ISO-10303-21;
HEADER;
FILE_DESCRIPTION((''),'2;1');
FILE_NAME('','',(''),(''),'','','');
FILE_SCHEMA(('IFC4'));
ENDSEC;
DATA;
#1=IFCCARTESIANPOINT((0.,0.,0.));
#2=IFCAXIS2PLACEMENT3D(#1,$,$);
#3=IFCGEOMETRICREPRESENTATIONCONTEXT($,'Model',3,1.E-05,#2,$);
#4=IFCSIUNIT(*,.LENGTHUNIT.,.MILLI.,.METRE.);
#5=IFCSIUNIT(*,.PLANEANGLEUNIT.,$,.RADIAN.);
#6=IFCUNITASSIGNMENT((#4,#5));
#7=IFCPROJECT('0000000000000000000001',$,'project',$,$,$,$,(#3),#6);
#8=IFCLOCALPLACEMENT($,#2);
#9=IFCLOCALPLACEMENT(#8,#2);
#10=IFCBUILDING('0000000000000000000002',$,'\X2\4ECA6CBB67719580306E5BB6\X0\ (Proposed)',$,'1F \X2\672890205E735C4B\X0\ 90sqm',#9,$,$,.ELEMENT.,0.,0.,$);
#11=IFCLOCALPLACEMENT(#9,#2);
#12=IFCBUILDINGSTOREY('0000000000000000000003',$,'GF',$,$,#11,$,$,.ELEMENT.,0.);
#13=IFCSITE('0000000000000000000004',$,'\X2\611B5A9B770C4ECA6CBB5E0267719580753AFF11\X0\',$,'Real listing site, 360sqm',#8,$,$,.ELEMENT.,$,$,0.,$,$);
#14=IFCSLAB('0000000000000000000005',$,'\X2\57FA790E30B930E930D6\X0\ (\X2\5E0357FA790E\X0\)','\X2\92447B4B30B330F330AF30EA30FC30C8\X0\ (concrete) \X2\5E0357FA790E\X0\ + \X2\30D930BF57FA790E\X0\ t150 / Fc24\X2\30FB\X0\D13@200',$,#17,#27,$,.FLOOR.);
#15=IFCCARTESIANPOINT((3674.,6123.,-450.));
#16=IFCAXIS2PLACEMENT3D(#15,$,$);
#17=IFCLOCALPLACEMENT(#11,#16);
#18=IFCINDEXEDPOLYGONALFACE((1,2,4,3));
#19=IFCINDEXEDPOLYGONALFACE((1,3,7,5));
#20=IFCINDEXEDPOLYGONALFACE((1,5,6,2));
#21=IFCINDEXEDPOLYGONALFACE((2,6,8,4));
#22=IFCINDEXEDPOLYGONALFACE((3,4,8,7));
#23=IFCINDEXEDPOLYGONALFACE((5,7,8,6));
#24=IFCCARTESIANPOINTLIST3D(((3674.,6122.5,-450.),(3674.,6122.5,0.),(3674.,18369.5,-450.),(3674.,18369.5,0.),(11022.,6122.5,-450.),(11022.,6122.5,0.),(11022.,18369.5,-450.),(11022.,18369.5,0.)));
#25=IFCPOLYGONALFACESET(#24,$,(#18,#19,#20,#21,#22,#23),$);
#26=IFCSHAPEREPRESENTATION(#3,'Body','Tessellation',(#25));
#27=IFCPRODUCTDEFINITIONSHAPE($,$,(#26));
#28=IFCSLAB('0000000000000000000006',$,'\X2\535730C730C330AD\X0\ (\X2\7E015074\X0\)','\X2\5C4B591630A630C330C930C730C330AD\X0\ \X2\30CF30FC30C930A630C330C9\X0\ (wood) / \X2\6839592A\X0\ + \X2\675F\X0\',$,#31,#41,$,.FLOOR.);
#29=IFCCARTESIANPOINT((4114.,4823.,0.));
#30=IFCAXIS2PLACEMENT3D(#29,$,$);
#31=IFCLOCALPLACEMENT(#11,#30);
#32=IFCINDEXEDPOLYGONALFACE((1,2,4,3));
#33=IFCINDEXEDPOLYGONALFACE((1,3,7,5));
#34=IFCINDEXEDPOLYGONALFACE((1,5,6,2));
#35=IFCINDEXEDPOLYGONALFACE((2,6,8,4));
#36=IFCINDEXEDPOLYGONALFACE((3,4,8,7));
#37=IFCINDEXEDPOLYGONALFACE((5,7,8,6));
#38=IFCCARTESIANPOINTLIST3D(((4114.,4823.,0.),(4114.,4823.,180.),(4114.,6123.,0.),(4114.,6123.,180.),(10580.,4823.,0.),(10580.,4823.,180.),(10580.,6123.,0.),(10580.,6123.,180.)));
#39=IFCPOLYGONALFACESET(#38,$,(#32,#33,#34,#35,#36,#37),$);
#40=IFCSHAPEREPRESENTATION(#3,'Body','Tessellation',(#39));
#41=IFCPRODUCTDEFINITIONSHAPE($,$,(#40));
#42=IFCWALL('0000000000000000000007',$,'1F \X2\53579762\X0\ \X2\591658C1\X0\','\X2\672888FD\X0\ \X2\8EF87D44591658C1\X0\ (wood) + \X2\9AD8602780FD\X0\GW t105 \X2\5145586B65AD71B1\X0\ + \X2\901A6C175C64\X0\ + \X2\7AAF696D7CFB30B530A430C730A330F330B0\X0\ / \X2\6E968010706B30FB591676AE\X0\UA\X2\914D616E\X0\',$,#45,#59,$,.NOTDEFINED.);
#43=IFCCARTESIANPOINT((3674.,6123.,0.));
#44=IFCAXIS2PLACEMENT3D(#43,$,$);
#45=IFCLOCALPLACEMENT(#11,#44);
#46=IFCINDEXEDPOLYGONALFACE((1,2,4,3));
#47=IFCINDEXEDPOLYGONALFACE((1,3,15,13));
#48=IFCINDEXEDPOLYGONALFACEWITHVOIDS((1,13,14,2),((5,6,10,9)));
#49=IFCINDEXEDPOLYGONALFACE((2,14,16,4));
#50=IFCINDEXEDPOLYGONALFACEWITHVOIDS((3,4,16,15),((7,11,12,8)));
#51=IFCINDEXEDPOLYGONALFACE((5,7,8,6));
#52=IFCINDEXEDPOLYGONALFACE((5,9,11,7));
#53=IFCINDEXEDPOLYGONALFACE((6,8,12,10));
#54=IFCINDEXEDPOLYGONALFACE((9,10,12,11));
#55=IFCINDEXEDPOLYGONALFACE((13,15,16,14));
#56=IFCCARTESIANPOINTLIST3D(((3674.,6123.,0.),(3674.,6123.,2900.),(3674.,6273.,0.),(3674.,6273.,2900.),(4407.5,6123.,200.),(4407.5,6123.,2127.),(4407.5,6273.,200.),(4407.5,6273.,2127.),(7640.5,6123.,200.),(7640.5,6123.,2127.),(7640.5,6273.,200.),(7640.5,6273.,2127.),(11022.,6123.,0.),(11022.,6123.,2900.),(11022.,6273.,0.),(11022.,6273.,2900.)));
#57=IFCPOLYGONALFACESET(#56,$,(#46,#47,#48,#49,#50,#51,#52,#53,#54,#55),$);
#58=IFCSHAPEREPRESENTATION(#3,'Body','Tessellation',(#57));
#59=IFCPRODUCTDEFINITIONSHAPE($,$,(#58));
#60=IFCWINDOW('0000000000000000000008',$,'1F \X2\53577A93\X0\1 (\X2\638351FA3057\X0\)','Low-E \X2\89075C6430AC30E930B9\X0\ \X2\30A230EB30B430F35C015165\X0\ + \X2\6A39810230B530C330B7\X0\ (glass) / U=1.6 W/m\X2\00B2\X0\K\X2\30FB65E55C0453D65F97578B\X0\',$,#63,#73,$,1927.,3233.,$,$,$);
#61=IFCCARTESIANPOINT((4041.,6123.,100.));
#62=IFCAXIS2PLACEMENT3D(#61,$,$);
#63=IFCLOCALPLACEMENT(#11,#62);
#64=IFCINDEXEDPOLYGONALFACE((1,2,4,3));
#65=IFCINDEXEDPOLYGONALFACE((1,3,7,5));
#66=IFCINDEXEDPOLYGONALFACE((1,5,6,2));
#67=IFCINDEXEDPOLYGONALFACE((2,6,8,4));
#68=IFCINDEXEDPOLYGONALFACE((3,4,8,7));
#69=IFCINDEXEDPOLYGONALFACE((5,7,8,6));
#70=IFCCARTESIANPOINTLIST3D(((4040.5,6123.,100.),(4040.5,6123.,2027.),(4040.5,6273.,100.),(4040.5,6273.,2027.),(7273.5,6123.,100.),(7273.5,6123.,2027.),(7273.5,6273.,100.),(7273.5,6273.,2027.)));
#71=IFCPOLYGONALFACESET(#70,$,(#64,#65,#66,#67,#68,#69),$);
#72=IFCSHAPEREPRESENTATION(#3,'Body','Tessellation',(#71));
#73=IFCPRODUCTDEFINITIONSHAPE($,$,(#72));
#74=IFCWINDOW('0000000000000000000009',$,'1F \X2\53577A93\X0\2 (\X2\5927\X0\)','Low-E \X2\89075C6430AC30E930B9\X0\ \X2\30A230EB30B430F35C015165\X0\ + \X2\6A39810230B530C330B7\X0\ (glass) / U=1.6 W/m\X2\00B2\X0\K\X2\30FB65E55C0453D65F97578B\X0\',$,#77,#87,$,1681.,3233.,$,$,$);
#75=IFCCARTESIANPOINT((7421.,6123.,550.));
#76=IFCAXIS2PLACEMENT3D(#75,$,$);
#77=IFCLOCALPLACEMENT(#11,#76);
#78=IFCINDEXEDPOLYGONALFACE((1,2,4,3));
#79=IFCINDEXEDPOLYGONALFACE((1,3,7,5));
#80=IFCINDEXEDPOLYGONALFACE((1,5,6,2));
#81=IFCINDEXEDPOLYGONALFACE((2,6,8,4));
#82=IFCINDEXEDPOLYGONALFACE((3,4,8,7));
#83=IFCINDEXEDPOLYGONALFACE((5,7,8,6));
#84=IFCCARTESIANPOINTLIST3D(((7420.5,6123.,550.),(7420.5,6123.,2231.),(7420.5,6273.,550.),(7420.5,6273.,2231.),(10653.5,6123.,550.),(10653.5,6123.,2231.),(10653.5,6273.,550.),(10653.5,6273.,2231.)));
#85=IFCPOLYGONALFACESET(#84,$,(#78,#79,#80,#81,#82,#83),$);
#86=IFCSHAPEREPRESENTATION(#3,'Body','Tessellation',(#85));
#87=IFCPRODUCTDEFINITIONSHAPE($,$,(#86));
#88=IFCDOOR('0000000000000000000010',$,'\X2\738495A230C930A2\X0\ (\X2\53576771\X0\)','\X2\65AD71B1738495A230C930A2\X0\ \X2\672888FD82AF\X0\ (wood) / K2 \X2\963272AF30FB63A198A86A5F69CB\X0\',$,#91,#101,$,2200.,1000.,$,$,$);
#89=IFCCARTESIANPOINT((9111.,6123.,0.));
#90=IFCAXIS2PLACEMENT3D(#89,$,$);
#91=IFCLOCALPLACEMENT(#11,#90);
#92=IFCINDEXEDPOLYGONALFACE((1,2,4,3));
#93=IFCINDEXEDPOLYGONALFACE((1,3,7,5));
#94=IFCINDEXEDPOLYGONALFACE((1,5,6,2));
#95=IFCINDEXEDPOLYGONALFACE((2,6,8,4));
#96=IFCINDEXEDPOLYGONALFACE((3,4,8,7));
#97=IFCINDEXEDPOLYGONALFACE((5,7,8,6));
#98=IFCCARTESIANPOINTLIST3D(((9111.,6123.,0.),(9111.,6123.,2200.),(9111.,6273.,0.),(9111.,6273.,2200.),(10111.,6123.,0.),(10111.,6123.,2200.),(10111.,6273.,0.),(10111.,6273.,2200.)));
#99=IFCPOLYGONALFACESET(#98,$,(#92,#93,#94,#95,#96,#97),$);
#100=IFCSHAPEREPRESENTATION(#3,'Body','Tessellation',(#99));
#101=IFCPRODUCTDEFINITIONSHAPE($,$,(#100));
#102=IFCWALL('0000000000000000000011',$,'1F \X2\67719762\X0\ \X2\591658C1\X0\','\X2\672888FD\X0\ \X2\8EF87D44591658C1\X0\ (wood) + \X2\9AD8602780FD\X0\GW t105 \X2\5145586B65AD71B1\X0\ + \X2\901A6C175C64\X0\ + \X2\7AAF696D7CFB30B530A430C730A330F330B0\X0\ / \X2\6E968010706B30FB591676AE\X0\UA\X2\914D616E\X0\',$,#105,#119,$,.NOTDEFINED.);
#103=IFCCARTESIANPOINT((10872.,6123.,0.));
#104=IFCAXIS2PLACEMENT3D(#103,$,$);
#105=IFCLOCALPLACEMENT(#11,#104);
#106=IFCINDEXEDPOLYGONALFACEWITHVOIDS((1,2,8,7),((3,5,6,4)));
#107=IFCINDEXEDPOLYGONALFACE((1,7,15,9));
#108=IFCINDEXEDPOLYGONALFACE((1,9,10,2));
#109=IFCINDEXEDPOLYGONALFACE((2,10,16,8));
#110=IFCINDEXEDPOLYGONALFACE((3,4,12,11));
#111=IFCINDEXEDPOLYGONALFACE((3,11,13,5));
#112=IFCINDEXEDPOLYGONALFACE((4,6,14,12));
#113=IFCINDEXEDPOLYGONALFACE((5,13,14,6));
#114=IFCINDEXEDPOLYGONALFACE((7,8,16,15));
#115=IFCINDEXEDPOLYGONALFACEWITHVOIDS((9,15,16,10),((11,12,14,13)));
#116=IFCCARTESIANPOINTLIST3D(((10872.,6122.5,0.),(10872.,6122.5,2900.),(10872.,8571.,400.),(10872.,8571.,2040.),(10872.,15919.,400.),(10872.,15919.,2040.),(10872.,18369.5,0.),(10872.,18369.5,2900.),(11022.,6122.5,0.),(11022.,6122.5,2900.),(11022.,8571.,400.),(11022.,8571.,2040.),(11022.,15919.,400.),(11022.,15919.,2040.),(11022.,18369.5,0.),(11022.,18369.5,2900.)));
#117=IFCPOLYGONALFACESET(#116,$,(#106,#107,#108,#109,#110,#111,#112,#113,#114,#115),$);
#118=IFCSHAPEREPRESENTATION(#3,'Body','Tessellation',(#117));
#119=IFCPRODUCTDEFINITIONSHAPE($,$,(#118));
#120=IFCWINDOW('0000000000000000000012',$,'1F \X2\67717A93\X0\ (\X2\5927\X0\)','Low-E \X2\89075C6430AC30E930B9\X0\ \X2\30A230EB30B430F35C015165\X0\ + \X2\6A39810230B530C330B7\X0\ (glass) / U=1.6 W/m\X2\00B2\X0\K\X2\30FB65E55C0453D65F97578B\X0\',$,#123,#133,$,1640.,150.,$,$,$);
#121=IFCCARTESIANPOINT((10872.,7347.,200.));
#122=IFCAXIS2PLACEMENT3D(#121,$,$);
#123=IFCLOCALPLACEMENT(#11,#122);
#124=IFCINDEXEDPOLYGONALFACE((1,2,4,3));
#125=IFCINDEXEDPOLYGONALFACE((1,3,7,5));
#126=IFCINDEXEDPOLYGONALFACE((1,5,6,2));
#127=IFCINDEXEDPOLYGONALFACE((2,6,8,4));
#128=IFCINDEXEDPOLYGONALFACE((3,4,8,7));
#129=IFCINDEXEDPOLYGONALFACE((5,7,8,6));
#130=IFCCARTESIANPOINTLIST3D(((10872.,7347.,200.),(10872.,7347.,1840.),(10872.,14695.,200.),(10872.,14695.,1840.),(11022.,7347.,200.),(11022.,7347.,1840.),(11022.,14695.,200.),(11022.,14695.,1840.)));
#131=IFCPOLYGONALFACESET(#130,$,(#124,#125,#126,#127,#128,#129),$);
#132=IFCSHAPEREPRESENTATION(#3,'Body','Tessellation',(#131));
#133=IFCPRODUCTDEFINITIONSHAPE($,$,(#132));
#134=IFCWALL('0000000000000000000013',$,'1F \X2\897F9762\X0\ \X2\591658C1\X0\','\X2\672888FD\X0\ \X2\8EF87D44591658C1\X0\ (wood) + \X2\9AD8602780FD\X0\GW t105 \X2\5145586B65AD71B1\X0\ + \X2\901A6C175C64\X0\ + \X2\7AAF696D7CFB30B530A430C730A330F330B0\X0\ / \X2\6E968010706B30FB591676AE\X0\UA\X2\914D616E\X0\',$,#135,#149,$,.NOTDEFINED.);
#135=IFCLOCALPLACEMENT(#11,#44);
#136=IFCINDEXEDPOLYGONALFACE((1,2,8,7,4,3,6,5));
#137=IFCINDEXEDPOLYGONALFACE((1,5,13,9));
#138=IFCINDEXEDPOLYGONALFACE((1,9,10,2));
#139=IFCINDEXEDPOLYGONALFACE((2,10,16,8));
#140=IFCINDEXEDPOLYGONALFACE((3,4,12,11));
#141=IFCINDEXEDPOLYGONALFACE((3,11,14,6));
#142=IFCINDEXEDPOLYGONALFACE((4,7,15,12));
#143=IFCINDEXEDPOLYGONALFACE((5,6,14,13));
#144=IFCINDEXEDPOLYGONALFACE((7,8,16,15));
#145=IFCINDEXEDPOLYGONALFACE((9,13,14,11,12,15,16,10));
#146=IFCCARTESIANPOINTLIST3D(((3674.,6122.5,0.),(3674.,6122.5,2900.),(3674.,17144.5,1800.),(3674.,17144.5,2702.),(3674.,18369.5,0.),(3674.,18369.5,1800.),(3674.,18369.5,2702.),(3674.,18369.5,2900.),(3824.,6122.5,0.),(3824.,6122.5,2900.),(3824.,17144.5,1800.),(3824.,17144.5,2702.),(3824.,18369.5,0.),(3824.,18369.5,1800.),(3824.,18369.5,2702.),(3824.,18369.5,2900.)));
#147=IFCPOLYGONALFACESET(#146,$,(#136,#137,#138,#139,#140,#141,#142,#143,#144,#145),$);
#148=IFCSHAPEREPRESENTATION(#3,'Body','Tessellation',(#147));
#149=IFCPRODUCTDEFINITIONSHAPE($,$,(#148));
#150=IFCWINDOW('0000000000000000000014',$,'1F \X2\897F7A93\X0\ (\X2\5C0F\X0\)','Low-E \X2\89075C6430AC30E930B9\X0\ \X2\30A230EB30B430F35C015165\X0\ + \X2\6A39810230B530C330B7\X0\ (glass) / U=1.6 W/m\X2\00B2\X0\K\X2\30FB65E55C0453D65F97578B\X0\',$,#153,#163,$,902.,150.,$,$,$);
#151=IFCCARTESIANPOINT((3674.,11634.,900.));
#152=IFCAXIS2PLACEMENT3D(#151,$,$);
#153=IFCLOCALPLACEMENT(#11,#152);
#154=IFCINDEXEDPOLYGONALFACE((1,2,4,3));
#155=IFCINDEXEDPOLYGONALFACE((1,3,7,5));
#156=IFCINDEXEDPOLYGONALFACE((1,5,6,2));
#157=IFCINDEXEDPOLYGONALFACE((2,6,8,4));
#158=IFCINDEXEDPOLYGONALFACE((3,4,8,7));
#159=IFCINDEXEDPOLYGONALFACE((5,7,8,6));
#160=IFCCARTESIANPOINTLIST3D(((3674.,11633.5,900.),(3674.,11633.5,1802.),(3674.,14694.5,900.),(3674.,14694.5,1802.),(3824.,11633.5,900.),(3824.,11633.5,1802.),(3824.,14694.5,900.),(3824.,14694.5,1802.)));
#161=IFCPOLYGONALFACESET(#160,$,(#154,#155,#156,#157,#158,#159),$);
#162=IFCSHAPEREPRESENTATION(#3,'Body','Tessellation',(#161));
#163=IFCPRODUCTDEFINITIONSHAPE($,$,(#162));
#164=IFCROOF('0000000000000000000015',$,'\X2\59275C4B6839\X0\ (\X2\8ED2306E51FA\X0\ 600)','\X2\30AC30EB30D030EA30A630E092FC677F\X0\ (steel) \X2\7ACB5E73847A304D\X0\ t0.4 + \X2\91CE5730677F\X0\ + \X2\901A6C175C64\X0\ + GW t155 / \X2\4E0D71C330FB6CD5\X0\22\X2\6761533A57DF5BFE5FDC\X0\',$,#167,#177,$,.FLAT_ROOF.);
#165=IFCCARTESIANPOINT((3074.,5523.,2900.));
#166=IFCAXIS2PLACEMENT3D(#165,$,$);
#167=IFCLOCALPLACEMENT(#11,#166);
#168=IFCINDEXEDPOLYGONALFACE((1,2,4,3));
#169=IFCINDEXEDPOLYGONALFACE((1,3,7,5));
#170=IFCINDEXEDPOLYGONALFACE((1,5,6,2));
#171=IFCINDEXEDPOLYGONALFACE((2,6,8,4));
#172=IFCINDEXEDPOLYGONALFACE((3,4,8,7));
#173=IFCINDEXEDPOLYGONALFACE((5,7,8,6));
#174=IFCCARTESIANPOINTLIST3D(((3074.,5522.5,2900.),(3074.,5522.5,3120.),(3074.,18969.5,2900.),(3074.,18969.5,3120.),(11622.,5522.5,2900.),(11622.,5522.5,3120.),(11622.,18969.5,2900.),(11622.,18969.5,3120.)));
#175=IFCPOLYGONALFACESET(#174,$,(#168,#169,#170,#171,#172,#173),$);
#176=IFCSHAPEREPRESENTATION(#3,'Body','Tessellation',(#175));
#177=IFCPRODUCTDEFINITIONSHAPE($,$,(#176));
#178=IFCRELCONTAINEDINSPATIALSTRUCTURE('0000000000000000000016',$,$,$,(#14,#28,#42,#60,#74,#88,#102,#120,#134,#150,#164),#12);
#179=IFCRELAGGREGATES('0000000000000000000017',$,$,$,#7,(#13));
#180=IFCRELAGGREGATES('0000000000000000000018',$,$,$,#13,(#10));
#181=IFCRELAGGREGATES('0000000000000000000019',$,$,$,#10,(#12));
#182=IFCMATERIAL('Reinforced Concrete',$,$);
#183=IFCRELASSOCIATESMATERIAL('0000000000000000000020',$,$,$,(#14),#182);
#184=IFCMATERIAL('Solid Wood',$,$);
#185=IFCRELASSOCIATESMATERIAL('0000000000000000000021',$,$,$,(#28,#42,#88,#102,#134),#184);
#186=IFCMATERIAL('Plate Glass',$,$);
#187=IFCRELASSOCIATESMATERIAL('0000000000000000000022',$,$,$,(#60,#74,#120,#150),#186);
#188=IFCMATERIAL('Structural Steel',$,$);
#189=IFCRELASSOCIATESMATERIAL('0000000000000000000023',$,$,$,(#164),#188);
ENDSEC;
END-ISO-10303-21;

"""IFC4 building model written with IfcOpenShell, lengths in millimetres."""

from ifc_helpers import new_model, si_unit, frame, frame_2d, origin, place, context, project, spatial, rectangle, extrude, material, element, fill, save


model = new_model("IFC4")

# Units and contexts
model_context = context("Model", 3, precision=1e-05, world=origin())
ifc_project = project(units=[si_unit("LENGTHUNIT", "METRE", prefix="MILLI"), si_unit("PLANEANGLEUNIT", "RADIAN")], contexts=[model_context])

# Site, building, storey
site_placement = place(None, origin())
site = spatial("IfcSite", under=ifc_project, at=site_placement, Name="愛媛県今治市東門町１", ObjectType="Real listing site, 360sqm", CompositionType="ELEMENT", RefElevation=0.0)
building_placement = place(site_placement, origin())
building = spatial("IfcBuilding", under=site, at=building_placement, Name="今治東門の家 (Proposed)", ObjectType="1F 木造平屋 90sqm", CompositionType="ELEMENT", ElevationOfRefHeight=0.0, ElevationOfTerrain=0.0)
storey_placement = place(building_placement, origin())
storey = spatial("IfcBuildingStorey", under=building, at=storey_placement, Name="GF", CompositionType="ELEMENT", Elevation=0.0)

# Slabs
ifc_material_1 = material(Name="Reinforced Concrete")
slab_1_placement = place(storey_placement, frame((3674.0, 6123.0, -450.0)))
element("IfcSlab", 1, at=slab_1_placement, inside=storey, material=ifc_material_1, Name="基礎スラブ (布基礎)", Description="鉄筋コンクリート (concrete) 布基礎 + ベタ基礎 t150 / Fc24・D13@200", PredefinedType="FLOOR", context=model_context, shape_type="SweptSolid", body=[
    extrude(rectangle(XDim=7348.0, YDim=12247.0, at=frame_2d((3674.0, 6123.0))), frame((3674.0, 6123.0, -450.0)), (0.0, 0.0, 1.0), 450.0),
])
ifc_material_2 = material(Name="Solid Wood")
slab_2_placement = place(storey_placement, frame((4114.0, 4823.0, 0.0)))
element("IfcSlab", 2, at=slab_2_placement, inside=storey, material=ifc_material_2, Name="南デッキ (縁側)", Description="屋外ウッドデッキ ハードウッド (wood) / 根太 + 束", PredefinedType="FLOOR", context=model_context, shape_type="SweptSolid", body=[
    extrude(rectangle(XDim=6466.0, YDim=1300.0, at=frame_2d((3233.0, 650.0))), frame((4114.0, 4823.0, 0.0)), (0.0, 0.0, 1.0), 180.0),
])

# Wall, openings, windows, door
wall_1_placement = place(storey_placement, frame((3674.0, 6123.0, 0.0)))
wall_1 = element("IfcWall", 3, at=wall_1_placement, inside=storey, material=ifc_material_2, Name="1F 南面 外壁", Description="木製 軸組外壁 (wood) + 高性能GW t105 充填断熱 + 通気層 + 窯業系サイディング / 準耐火・外皮UA配慮", PredefinedType="NOTDEFINED", context=model_context, shape_type="SweptSolid", body=[
    extrude(rectangle(XDim=7348.0, YDim=150.0, at=frame_2d((3674.0, 75.0))), frame((3674.0, 6123.0, 0.0)), (0.0, 0.0, 1.0), 2900.0),
])
opening_1_placement = place(storey_placement, frame((4041.0, 6123.0, 100.0)))
opening_1 = element("IfcOpeningElement", 4, at=opening_1_placement, cuts=wall_1, PredefinedType="NOTDEFINED", context=model_context, shape_type="SweptSolid", body=[
    extrude(rectangle(XDim=3233.0, YDim=150.0, at=frame_2d((1616.0, 75.0))), frame((4041.0, 6123.0, 100.0)), (0.0, 0.0, 1.0), 1927.0),
])
opening_2_placement = place(storey_placement, frame((7421.0, 6123.0, 550.0)))
opening_2 = element("IfcOpeningElement", 5, at=opening_2_placement, cuts=wall_1, PredefinedType="NOTDEFINED", context=model_context, shape_type="SweptSolid", body=[
    extrude(rectangle(XDim=3233.0, YDim=150.0, at=frame_2d((1616.0, 75.0))), frame((7421.0, 6123.0, 550.0)), (0.0, 0.0, 1.0), 1681.0),
])
opening_3_placement = place(storey_placement, frame((9111.0, 6123.0, 0.0)))
opening_3 = element("IfcOpeningElement", 6, at=opening_3_placement, cuts=wall_1, PredefinedType="NOTDEFINED", context=model_context, shape_type="SweptSolid", body=[
    extrude(rectangle(XDim=1000.0, YDim=150.0, at=frame_2d((500.0, 75.0))), frame((9111.0, 6123.0, 0.0)), (0.0, 0.0, 1.0), 2200.0),
])
ifc_material_3 = material(Name="Plate Glass")
window_1_placement = place(storey_placement, frame((4041.0, 6123.0, 100.0)))
window_1 = element("IfcWindow", 7, at=window_1_placement, inside=storey, material=ifc_material_3, Name="1F 南窓1 (掃出し)", Description="Low-E 複層ガラス アルゴン封入 + 樹脂サッシ (glass) / U=1.6 W/m²K・日射取得型", OverallHeight=1927.0, OverallWidth=3233.0, context=model_context, shape_type="SweptSolid", body=[
    extrude(rectangle(XDim=3233.0, YDim=150.0, at=frame_2d((1616.0, 75.0))), frame((4041.0, 6123.0, 100.0)), (0.0, 0.0, 1.0), 1927.0),
])
fill(opening_1, window_1)
window_2_placement = place(storey_placement, frame((7421.0, 6123.0, 550.0)))
window_2 = element("IfcWindow", 8, at=window_2_placement, inside=storey, material=ifc_material_3, Name="1F 南窓2 (大)", Description="Low-E 複層ガラス アルゴン封入 + 樹脂サッシ (glass) / U=1.6 W/m²K・日射取得型", OverallHeight=1681.0, OverallWidth=3233.0, context=model_context, shape_type="SweptSolid", body=[
    extrude(rectangle(XDim=3233.0, YDim=150.0, at=frame_2d((1616.0, 75.0))), frame((7421.0, 6123.0, 550.0)), (0.0, 0.0, 1.0), 1681.0),
])
fill(opening_2, window_2)
door_placement = place(storey_placement, frame((9111.0, 6123.0, 0.0)))
door = element("IfcDoor", 9, at=door_placement, inside=storey, material=ifc_material_2, Name="玄関ドア (南東)", Description="断熱玄関ドア 木製芯 (wood) / K2 防犯・採風機構", OverallHeight=2200.0, OverallWidth=1000.0, context=model_context, shape_type="SweptSolid", body=[
    extrude(rectangle(XDim=1000.0, YDim=150.0, at=frame_2d((500.0, 75.0))), frame((9111.0, 6123.0, 0.0)), (0.0, 0.0, 1.0), 2200.0),
])
fill(opening_3, door)

# Walls, openings, windows
wall_2_placement = place(storey_placement, frame((10872.0, 6123.0, 0.0)))
wall_2 = element("IfcWall", 10, at=wall_2_placement, inside=storey, material=ifc_material_2, Name="1F 東面 外壁", Description="木製 軸組外壁 (wood) + 高性能GW t105 充填断熱 + 通気層 + 窯業系サイディング / 準耐火・外皮UA配慮", PredefinedType="NOTDEFINED", context=model_context, shape_type="SweptSolid", body=[
    extrude(rectangle(XDim=150.0, YDim=12247.0, at=frame_2d((75.0, 6123.0))), frame((10872.0, 6123.0, 0.0)), (0.0, 0.0, 1.0), 2900.0),
])
opening_4_placement = place(storey_placement, frame((10872.0, 7347.0, 200.0)))
opening_4 = element("IfcOpeningElement", 11, at=opening_4_placement, cuts=wall_2, PredefinedType="NOTDEFINED", context=model_context, shape_type="SweptSolid", body=[
    extrude(rectangle(XDim=150.0, YDim=7348.0, at=frame_2d((75.0, 3674.0))), frame((10872.0, 7347.0, 200.0)), (0.0, 0.0, 1.0), 1640.0),
])
window_3_placement = place(storey_placement, frame((10872.0, 7347.0, 200.0)))
window_3 = element("IfcWindow", 12, at=window_3_placement, inside=storey, material=ifc_material_3, Name="1F 東窓 (大)", Description="Low-E 複層ガラス アルゴン封入 + 樹脂サッシ (glass) / U=1.6 W/m²K・日射取得型", OverallHeight=1640.0, OverallWidth=150.0, context=model_context, shape_type="SweptSolid", body=[
    extrude(rectangle(XDim=150.0, YDim=7348.0, at=frame_2d((75.0, 3674.0))), frame((10872.0, 7347.0, 200.0)), (0.0, 0.0, 1.0), 1640.0),
])
fill(opening_4, window_3)
wall_3_placement = place(storey_placement, frame((3674.0, 6123.0, 0.0)))
wall_3 = element("IfcWall", 13, at=wall_3_placement, inside=storey, material=ifc_material_2, Name="1F 西面 外壁", Description="木製 軸組外壁 (wood) + 高性能GW t105 充填断熱 + 通気層 + 窯業系サイディング / 準耐火・外皮UA配慮", PredefinedType="NOTDEFINED", context=model_context, shape_type="SweptSolid", body=[
    extrude(rectangle(XDim=150.0, YDim=12247.0, at=frame_2d((75.0, 6123.0))), frame((3674.0, 6123.0, 0.0)), (0.0, 0.0, 1.0), 2900.0),
])
opening_5_placement = place(storey_placement, frame((3674.0, 11634.0, 900.0)))
opening_5 = element("IfcOpeningElement", 14, at=opening_5_placement, cuts=wall_3, PredefinedType="NOTDEFINED", context=model_context, shape_type="SweptSolid", body=[
    extrude(rectangle(XDim=150.0, YDim=3061.0, at=frame_2d((75.0, 1530.0))), frame((3674.0, 11634.0, 900.0)), (0.0, 0.0, 1.0), 902.0),
])
window_4_placement = place(storey_placement, frame((3674.0, 11634.0, 900.0)))
window_4 = element("IfcWindow", 15, at=window_4_placement, inside=storey, material=ifc_material_3, Name="1F 西窓 (小)", Description="Low-E 複層ガラス アルゴン封入 + 樹脂サッシ (glass) / U=1.6 W/m²K・日射取得型", OverallHeight=902.0, OverallWidth=150.0, context=model_context, shape_type="SweptSolid", body=[
    extrude(rectangle(XDim=150.0, YDim=3061.0, at=frame_2d((75.0, 1530.0))), frame((3674.0, 11634.0, 900.0)), (0.0, 0.0, 1.0), 902.0),
])
fill(opening_5, window_4)

# Roof
ifc_material_4 = material(Name="Structural Steel")
roof_placement = place(storey_placement, frame((3074.0, 5523.0, 2900.0)))
element("IfcRoof", 16, at=roof_placement, inside=storey, material=ifc_material_4, Name="大屋根 (軒の出 600)", Description="ガルバリウム鋼板 (steel) 立平葺き t0.4 + 野地板 + 通気層 + GW t155 / 不燃・法22条区域対応", PredefinedType="FLAT_ROOF", context=model_context, shape_type="SweptSolid", body=[
    extrude(rectangle(XDim=8548.0, YDim=13447.0, at=frame_2d((4274.0, 6723.0))), frame((3074.0, 5523.0, 2900.0)), (0.0, 0.0, 1.0), 220.0),
])

save(model, "model.ifc")
